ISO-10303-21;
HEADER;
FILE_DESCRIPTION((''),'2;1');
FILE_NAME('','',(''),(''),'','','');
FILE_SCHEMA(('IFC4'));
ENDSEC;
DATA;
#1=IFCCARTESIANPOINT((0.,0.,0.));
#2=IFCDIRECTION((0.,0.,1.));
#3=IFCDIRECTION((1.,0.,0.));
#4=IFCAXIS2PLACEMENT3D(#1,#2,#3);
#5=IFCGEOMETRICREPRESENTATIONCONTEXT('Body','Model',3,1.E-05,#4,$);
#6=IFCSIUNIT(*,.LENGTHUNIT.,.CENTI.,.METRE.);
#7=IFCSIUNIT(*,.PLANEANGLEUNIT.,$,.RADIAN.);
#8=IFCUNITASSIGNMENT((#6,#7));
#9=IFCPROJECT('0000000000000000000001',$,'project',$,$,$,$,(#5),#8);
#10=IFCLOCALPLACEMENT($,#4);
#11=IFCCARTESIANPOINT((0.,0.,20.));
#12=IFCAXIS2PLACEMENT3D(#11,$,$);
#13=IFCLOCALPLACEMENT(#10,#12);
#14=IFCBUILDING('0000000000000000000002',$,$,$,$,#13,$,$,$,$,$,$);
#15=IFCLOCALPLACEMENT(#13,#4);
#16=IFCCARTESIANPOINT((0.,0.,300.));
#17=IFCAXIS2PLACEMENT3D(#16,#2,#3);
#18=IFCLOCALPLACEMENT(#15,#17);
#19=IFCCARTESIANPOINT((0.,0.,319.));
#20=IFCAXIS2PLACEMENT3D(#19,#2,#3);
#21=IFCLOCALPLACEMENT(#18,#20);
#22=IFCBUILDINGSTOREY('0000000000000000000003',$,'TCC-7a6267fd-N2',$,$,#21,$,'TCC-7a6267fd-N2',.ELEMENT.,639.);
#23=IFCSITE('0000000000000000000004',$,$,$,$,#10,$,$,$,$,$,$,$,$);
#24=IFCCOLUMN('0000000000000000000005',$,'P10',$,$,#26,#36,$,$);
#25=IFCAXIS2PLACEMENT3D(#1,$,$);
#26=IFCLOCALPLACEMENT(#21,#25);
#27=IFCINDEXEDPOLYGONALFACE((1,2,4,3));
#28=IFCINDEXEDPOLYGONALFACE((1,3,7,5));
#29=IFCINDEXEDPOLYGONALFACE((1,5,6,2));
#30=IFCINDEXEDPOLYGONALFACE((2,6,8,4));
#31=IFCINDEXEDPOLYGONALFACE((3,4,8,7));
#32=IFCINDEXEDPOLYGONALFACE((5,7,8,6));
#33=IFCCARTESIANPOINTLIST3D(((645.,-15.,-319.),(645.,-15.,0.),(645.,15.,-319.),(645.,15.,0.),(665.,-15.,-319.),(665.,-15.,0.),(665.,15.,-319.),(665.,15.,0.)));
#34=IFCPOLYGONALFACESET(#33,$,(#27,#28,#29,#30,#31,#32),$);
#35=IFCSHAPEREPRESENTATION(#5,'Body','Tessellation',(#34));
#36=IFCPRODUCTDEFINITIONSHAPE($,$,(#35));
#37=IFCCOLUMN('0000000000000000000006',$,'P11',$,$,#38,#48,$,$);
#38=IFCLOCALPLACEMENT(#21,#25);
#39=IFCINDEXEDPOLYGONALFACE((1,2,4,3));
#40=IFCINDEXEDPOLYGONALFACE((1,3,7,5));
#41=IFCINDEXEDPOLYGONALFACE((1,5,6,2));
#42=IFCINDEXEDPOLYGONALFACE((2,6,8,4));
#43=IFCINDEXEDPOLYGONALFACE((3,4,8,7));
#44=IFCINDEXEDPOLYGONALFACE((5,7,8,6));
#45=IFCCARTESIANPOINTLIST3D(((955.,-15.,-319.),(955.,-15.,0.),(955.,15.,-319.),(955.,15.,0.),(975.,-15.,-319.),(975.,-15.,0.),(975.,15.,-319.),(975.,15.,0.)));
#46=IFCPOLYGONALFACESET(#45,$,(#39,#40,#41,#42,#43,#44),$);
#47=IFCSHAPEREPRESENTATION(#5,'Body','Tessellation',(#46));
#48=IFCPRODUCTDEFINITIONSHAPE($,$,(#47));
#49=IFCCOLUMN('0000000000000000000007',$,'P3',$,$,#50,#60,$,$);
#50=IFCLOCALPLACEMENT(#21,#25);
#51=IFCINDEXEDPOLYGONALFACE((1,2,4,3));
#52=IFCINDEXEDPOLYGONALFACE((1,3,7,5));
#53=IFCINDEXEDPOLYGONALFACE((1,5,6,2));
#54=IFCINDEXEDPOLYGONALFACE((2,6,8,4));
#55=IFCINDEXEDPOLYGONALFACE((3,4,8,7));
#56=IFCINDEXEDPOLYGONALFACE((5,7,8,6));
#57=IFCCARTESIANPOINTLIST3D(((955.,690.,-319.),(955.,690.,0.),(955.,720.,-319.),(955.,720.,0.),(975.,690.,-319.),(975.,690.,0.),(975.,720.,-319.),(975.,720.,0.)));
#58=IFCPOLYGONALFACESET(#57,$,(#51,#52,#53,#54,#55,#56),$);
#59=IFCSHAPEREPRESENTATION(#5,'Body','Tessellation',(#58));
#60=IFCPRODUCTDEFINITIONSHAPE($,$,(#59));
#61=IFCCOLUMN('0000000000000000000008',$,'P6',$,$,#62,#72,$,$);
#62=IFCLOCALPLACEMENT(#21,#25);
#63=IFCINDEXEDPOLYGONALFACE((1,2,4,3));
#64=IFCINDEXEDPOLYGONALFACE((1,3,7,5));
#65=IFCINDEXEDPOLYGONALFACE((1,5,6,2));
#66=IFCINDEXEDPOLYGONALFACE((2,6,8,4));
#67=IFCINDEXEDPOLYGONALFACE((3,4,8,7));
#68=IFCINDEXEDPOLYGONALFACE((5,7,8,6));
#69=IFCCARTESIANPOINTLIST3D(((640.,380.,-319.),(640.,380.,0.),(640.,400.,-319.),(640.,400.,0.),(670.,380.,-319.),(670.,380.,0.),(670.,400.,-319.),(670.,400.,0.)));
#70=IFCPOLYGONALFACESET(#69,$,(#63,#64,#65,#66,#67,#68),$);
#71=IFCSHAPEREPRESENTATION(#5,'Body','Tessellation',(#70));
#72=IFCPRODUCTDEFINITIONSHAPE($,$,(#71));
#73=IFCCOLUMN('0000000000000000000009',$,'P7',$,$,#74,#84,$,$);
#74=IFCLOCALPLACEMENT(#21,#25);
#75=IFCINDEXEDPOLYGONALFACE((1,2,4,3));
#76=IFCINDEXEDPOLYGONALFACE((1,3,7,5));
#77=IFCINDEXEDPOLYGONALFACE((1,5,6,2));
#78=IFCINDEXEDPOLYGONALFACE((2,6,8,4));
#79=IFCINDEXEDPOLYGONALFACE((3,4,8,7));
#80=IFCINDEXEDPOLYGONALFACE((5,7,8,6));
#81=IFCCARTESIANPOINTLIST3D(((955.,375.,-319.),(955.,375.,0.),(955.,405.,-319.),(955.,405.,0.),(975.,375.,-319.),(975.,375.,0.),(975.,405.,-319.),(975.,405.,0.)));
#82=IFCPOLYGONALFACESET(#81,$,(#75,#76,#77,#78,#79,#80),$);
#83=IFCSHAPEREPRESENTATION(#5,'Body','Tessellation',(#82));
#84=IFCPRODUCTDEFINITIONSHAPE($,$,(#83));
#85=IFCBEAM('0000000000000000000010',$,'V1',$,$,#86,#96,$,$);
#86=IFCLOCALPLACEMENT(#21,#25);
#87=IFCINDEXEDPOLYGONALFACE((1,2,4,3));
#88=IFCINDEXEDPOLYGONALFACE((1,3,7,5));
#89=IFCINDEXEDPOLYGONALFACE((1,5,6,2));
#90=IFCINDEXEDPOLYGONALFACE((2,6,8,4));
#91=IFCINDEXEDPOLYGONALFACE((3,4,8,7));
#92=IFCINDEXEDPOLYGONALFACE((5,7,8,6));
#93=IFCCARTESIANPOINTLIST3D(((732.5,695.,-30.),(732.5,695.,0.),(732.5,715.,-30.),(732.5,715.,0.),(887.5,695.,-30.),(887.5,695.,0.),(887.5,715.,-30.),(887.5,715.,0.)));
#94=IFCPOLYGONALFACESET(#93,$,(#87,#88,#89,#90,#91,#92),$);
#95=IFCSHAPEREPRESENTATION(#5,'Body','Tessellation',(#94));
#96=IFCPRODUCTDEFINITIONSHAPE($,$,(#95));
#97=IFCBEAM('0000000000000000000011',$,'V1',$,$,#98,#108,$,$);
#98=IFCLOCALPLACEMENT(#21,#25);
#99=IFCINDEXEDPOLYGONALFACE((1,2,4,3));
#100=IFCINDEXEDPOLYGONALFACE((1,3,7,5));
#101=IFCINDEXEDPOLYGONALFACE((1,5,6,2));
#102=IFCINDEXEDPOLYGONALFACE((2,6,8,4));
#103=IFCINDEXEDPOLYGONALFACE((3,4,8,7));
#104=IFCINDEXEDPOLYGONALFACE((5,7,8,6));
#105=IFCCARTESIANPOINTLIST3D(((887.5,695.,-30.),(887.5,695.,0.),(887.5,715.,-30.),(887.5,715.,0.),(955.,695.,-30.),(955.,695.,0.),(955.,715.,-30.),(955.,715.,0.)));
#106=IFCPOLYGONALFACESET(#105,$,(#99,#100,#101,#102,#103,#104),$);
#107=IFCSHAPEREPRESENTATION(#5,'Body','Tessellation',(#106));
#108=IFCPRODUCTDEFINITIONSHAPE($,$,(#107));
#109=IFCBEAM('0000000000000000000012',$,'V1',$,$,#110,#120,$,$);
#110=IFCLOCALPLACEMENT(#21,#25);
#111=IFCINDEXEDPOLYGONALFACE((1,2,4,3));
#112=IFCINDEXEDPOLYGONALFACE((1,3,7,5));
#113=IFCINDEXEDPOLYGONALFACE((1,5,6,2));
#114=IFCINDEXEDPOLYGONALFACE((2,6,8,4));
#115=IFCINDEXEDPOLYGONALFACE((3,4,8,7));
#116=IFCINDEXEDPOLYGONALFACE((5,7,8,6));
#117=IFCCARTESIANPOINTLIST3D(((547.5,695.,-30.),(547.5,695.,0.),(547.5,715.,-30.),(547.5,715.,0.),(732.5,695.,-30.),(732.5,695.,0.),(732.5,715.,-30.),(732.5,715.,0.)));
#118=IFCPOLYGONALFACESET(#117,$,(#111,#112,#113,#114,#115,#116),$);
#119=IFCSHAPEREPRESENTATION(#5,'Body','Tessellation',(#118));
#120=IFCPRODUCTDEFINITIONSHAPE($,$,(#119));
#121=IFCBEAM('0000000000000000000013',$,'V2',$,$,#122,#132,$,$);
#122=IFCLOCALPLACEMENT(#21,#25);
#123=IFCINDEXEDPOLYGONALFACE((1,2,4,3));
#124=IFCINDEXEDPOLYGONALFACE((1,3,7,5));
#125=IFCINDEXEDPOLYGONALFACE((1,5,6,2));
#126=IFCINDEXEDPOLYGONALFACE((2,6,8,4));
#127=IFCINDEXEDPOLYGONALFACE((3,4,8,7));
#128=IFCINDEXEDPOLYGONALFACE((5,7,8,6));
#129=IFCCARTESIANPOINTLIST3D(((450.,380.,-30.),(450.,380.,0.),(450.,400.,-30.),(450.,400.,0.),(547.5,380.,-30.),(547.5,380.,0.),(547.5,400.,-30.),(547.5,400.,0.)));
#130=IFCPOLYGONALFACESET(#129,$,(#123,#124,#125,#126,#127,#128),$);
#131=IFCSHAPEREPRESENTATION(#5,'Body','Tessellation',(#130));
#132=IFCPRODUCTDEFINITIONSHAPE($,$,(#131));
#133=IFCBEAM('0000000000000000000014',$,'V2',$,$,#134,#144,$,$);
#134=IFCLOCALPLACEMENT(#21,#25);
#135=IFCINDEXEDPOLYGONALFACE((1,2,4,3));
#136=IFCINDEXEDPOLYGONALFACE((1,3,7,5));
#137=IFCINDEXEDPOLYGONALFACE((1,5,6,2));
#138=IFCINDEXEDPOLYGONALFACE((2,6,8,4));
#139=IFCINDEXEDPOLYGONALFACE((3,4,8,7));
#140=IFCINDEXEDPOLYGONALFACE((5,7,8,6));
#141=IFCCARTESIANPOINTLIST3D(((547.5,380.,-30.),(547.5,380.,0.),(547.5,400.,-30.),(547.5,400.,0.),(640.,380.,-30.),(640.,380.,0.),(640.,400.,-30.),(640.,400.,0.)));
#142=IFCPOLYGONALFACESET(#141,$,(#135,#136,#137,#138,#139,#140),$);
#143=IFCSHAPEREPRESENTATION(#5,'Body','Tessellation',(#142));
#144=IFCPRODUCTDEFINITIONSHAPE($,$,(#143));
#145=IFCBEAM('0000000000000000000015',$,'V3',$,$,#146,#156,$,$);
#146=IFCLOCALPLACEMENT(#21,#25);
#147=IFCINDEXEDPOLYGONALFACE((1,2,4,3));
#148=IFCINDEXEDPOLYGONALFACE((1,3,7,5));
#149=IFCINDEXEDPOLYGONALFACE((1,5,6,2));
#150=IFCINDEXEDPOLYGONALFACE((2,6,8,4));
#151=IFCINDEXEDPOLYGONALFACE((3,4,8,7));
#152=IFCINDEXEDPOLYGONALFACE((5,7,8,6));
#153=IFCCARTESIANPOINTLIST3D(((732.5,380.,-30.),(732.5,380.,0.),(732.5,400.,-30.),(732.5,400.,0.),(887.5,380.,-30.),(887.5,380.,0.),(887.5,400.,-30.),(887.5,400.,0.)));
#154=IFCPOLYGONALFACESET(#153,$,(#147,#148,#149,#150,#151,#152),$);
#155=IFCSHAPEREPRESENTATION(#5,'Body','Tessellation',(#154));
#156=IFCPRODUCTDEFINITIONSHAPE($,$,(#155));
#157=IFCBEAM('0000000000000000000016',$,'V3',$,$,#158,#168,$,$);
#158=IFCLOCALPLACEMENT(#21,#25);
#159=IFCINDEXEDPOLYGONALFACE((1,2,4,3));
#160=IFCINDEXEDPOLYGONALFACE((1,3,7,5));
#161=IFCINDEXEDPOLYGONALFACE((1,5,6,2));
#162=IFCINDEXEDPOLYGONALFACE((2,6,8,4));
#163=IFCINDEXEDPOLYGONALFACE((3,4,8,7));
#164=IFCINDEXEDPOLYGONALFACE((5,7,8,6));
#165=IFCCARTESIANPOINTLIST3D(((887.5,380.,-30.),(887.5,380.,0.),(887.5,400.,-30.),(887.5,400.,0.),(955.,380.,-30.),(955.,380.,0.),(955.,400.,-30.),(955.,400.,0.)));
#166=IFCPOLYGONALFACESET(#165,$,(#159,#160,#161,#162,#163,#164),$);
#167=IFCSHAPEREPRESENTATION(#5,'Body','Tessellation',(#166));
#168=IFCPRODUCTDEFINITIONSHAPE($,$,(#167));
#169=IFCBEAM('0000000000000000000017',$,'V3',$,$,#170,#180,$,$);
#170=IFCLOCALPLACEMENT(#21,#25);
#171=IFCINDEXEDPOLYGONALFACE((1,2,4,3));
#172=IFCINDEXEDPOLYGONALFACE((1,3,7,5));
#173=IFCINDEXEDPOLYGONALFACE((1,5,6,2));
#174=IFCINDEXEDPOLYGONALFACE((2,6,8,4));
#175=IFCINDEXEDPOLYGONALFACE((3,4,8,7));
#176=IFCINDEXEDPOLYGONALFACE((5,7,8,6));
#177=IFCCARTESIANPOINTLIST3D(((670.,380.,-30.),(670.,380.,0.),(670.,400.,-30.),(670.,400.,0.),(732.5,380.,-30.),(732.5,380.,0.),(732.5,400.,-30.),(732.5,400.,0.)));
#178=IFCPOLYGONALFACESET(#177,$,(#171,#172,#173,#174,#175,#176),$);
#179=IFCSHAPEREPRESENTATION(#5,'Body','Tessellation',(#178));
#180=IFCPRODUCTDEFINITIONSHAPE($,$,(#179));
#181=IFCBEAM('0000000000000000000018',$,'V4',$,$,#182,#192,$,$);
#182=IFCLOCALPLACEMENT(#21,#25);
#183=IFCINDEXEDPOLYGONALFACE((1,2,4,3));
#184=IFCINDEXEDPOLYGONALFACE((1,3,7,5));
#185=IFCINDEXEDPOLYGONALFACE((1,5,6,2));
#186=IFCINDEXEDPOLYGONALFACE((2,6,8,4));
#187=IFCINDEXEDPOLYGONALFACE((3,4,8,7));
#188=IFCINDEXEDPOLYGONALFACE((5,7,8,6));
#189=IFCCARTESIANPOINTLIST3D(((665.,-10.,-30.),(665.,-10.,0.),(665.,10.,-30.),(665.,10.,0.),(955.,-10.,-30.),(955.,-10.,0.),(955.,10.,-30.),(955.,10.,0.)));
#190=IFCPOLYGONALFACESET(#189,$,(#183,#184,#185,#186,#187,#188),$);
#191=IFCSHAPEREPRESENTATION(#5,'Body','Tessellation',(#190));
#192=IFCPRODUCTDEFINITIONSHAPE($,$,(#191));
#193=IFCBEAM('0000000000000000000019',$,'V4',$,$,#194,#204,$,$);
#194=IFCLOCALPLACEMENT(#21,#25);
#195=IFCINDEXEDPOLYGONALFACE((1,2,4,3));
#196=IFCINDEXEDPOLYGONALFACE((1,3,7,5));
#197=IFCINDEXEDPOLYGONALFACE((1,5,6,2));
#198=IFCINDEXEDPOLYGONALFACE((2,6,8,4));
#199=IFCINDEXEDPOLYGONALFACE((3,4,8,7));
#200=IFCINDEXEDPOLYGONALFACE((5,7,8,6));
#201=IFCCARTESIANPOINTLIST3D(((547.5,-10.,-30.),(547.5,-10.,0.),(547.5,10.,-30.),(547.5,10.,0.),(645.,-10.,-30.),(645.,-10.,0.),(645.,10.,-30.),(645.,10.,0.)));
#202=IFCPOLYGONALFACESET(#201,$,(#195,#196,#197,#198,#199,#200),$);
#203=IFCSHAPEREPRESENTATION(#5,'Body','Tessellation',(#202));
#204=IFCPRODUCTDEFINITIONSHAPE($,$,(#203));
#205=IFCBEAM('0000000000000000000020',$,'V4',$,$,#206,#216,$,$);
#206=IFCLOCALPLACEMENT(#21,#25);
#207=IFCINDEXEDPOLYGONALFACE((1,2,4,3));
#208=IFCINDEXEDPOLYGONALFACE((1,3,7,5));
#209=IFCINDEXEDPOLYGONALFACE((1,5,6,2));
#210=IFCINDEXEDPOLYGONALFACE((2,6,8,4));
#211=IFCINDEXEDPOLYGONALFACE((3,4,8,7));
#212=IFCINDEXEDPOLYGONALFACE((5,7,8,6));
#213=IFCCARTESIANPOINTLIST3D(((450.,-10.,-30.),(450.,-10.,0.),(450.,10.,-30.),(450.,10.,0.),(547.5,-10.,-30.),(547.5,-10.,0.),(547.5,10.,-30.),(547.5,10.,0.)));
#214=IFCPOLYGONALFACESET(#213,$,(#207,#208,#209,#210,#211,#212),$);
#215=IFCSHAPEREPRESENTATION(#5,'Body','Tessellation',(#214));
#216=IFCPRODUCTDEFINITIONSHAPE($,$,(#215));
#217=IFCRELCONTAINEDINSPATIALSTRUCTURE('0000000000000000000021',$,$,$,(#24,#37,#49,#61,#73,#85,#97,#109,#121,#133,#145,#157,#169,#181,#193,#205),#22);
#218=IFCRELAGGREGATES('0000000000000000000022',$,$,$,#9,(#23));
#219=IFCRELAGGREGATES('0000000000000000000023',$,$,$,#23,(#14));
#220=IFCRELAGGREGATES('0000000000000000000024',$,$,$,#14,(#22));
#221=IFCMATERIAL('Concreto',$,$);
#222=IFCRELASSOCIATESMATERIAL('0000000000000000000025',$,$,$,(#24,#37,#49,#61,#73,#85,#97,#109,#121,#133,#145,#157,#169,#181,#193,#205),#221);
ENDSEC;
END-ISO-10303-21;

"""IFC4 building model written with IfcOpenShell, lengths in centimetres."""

from ifc_helpers import new_model, si_unit, frame, origin_with_axes, origin_2d_with_axis, place, context, project, spatial, rectangle, extrude, material, element, save


model = new_model("IFC4")

# Units and contexts
model_context = context("Model", 3, precision=1e-05, world=origin_with_axes(), identifier="Body")
ifc_project = project(units=[si_unit("LENGTHUNIT", "METRE", prefix="CENTI"), si_unit("PLANEANGLEUNIT", "RADIAN")], contexts=[model_context])

# Site, building, storey
site_placement = place(None, origin_with_axes())
site = spatial("IfcSite", under=ifc_project, at=site_placement)
building_placement = place(site_placement, frame((0.0, 0.0, 20.0)))
building = spatial("IfcBuilding", under=site, at=building_placement)
placement_1 = place(building_placement, origin_with_axes())
placement_2 = place(placement_1, frame((0.0, 0.0, 300.0), z_axis=(0.0, 0.0, 1.0), x_axis=(1.0, 0.0, 0.0)))
storey_placement = place(placement_2, frame((0.0, 0.0, 319.0), z_axis=(0.0, 0.0, 1.0), x_axis=(1.0, 0.0, 0.0)))
storey = spatial("IfcBuildingStorey", under=building, at=storey_placement, Name="TCC-7a6267fd-N2", LongName="TCC-7a6267fd-N2", CompositionType="ELEMENT", Elevation=639.0)

# Columns
ifc_material = material(Name="Concreto")
for number, where, z_axis, x_axis, name in (
    (1, (655.0, 0.0, 0.0), (0.0, 0.0, 1.0), (1.0, 0.0, 0.0), "P10"),
    (2, (965.0, 0.0, 0.0), (0.0, 0.0, 1.0), (1.0, 0.0, 0.0), "P11"),
    (3, (965.0, 705.0, 0.0), (0.0, 0.0, 1.0), (1.0, 0.0, 0.0), "P3"),
):
    element("IfcColumn", number, at=place(storey_placement, frame(where, z_axis=z_axis, x_axis=x_axis)), inside=storey, material=ifc_material, Name=name, context=model_context, shape_type="SolidModel", body=[
        extrude(rectangle(XDim=20.0, YDim=30.0, at=origin_2d_with_axis()), origin_with_axes(), (0.0, 0.0, -1.0), 319.0),
    ])
column_1_placement = place(storey_placement, frame((655.0, 390.0, 0.0), z_axis=(0.0, 0.0, 1.0), x_axis=(1.0, 0.0, 0.0)))
element("IfcColumn", 4, at=column_1_placement, inside=storey, material=ifc_material, Name="P6", context=model_context, shape_type="SolidModel", body=[
    extrude(rectangle(XDim=20.0, YDim=30.0, at=origin_2d_with_axis()), frame((0.0, 0.0, 0.0), z_axis=(0.0, 0.0, 1.0), x_axis=(0.0, 1.0, 0.0)), (0.0, 0.0, -1.0), 319.0),
])
column_2_placement = place(storey_placement, frame((965.0, 390.0, 0.0), z_axis=(0.0, 0.0, 1.0), x_axis=(1.0, 0.0, 0.0)))
element("IfcColumn", 5, at=column_2_placement, inside=storey, material=ifc_material, Name="P7", context=model_context, shape_type="SolidModel", body=[
    extrude(rectangle(XDim=20.0, YDim=30.0, at=origin_2d_with_axis()), origin_with_axes(), (0.0, 0.0, -1.0), 319.0),
])

# Beams
beam_1_placement = place(storey_placement, frame((810.0, 705.0, 0.0), z_axis=(0.0, 0.0, 1.0), x_axis=(1.0, 0.0, 0.0)))
element("IfcBeam", 6, at=beam_1_placement, inside=storey, material=ifc_material, Name="V1", context=model_context, shape_type="SolidModel", body=[
    extrude(rectangle(XDim=20.0, YDim=30.0, at=origin_2d_with_axis()), frame((77.5, 0.0, -15.0), z_axis=(-1.0, 0.0, 0.0), x_axis=(0.0, 1.0, 0.0)), (0.0, 0.0, 1.0), 155.0),
])
beam_2_placement = place(storey_placement, frame((921.25, 705.0, 0.0), z_axis=(0.0, 0.0, 1.0), x_axis=(1.0, 0.0, 0.0)))
element("IfcBeam", 7, at=beam_2_placement, inside=storey, material=ifc_material, Name="V1", context=model_context, shape_type="SolidModel", body=[
    extrude(rectangle(XDim=20.0, YDim=30.0, at=origin_2d_with_axis()), frame((33.75, 0.0, -15.0), z_axis=(-1.0, 0.0, 0.0), x_axis=(0.0, 1.0, 0.0)), (0.0, 0.0, 1.0), 67.5),
])
beam_3_placement = place(storey_placement, frame((640.0, 705.0, 0.0), z_axis=(0.0, 0.0, 1.0), x_axis=(1.0, 0.0, 0.0)))
element("IfcBeam", 8, at=beam_3_placement, inside=storey, material=ifc_material, Name="V1", context=model_context, shape_type="SolidModel", body=[
    extrude(rectangle(XDim=20.0, YDim=30.0, at=origin_2d_with_axis()), frame((92.5, 0.0, -15.0), z_axis=(-1.0, 0.0, 0.0), x_axis=(0.0, 1.0, 0.0)), (0.0, 0.0, 1.0), 185.0),
])
beam_4_placement = place(storey_placement, frame((498.75, 390.0, 0.0), z_axis=(0.0, 0.0, 1.0), x_axis=(1.0, 0.0, 0.0)))
element("IfcBeam", 9, at=beam_4_placement, inside=storey, material=ifc_material, Name="V2", context=model_context, shape_type="SolidModel", body=[
    extrude(rectangle(XDim=20.0, YDim=30.0, at=origin_2d_with_axis()), frame((48.75, 0.0, -15.0), z_axis=(-1.0, 0.0, 0.0), x_axis=(0.0, 1.0, 0.0)), (0.0, 0.0, 1.0), 97.5),
])
beam_5_placement = place(storey_placement, frame((593.75, 390.0, 0.0), z_axis=(0.0, 0.0, 1.0), x_axis=(1.0, 0.0, 0.0)))
element("IfcBeam", 10, at=beam_5_placement, inside=storey, material=ifc_material, Name="V2", context=model_context, shape_type="SolidModel", body=[
    extrude(rectangle(XDim=20.0, YDim=30.0, at=origin_2d_with_axis()), frame((46.25, 0.0, -15.0), z_axis=(-1.0, 0.0, 0.0), x_axis=(0.0, 1.0, 0.0)), (0.0, 0.0, 1.0), 92.5),
])
beam_6_placement = place(storey_placement, frame((810.0, 390.0, 0.0), z_axis=(0.0, 0.0, 1.0), x_axis=(1.0, 0.0, 0.0)))
element("IfcBeam", 11, at=beam_6_placement, inside=storey, material=ifc_material, Name="V3", context=model_context, shape_type="SolidModel", body=[
    extrude(rectangle(XDim=20.0, YDim=30.0, at=origin_2d_with_axis()), frame((-77.5, 0.0, -15.0), z_axis=(1.0, 0.0, 0.0), x_axis=(0.0, 1.0, 0.0)), (0.0, 0.0, 1.0), 155.0),
])
beam_7_placement = place(storey_placement, frame((921.25, 390.0, 0.0), z_axis=(0.0, 0.0, 1.0), x_axis=(1.0, 0.0, 0.0)))
element("IfcBeam", 12, at=beam_7_placement, inside=storey, material=ifc_material, Name="V3", context=model_context, shape_type="SolidModel", body=[
    extrude(rectangle(XDim=20.0, YDim=30.0, at=origin_2d_with_axis()), frame((-33.75, 0.0, -15.0), z_axis=(1.0, 0.0, 0.0), x_axis=(0.0, 1.0, 0.0)), (0.0, 0.0, 1.0), 67.5),
])
beam_8_placement = place(storey_placement, frame((701.25, 390.0, 0.0), z_axis=(0.0, 0.0, 1.0), x_axis=(1.0, 0.0, 0.0)))
element("IfcBeam", 13, at=beam_8_placement, inside=storey, material=ifc_material, Name="V3", context=model_context, shape_type="SolidModel", body=[
    extrude(rectangle(XDim=20.0, YDim=30.0, at=origin_2d_with_axis()), frame((-31.25, 0.0, -15.0), z_axis=(1.0, 0.0, 0.0), x_axis=(0.0, 1.0, 0.0)), (0.0, 0.0, 1.0), 62.5),
])
beam_9_placement = place(storey_placement, frame((810.0, 0.0, 0.0), z_axis=(0.0, 0.0, 1.0), x_axis=(1.0, 0.0, 0.0)))
element("IfcBeam", 14, at=beam_9_placement, inside=storey, material=ifc_material, Name="V4", context=model_context, shape_type="SolidModel", body=[
    extrude(rectangle(XDim=20.0, YDim=30.0, at=origin_2d_with_axis()), frame((145.0, 0.0, -15.0), z_axis=(-1.0, 0.0, 0.0), x_axis=(0.0, 1.0, 0.0)), (0.0, 0.0, 1.0), 290.0),
])
for number, where, z_axis, x_axis, name in (
    (15, (596.25, 0.0, 0.0), (0.0, 0.0, 1.0), (1.0, 0.0, 0.0), "V4"),
    (16, (498.75, 0.0, 0.0), (0.0, 0.0, 1.0), (1.0, 0.0, 0.0), "V4"),
):
    element("IfcBeam", number, at=place(storey_placement, frame(where, z_axis=z_axis, x_axis=x_axis)), inside=storey, material=ifc_material, Name=name, context=model_context, shape_type="SolidModel", body=[
        extrude(rectangle(XDim=20.0, YDim=30.0, at=origin_2d_with_axis()), frame((48.75, 0.0, -15.0), z_axis=(-1.0, 0.0, 0.0), x_axis=(0.0, 1.0, 0.0)), (0.0, 0.0, 1.0), 97.5),
    ])

save(model, "model.ifc")
